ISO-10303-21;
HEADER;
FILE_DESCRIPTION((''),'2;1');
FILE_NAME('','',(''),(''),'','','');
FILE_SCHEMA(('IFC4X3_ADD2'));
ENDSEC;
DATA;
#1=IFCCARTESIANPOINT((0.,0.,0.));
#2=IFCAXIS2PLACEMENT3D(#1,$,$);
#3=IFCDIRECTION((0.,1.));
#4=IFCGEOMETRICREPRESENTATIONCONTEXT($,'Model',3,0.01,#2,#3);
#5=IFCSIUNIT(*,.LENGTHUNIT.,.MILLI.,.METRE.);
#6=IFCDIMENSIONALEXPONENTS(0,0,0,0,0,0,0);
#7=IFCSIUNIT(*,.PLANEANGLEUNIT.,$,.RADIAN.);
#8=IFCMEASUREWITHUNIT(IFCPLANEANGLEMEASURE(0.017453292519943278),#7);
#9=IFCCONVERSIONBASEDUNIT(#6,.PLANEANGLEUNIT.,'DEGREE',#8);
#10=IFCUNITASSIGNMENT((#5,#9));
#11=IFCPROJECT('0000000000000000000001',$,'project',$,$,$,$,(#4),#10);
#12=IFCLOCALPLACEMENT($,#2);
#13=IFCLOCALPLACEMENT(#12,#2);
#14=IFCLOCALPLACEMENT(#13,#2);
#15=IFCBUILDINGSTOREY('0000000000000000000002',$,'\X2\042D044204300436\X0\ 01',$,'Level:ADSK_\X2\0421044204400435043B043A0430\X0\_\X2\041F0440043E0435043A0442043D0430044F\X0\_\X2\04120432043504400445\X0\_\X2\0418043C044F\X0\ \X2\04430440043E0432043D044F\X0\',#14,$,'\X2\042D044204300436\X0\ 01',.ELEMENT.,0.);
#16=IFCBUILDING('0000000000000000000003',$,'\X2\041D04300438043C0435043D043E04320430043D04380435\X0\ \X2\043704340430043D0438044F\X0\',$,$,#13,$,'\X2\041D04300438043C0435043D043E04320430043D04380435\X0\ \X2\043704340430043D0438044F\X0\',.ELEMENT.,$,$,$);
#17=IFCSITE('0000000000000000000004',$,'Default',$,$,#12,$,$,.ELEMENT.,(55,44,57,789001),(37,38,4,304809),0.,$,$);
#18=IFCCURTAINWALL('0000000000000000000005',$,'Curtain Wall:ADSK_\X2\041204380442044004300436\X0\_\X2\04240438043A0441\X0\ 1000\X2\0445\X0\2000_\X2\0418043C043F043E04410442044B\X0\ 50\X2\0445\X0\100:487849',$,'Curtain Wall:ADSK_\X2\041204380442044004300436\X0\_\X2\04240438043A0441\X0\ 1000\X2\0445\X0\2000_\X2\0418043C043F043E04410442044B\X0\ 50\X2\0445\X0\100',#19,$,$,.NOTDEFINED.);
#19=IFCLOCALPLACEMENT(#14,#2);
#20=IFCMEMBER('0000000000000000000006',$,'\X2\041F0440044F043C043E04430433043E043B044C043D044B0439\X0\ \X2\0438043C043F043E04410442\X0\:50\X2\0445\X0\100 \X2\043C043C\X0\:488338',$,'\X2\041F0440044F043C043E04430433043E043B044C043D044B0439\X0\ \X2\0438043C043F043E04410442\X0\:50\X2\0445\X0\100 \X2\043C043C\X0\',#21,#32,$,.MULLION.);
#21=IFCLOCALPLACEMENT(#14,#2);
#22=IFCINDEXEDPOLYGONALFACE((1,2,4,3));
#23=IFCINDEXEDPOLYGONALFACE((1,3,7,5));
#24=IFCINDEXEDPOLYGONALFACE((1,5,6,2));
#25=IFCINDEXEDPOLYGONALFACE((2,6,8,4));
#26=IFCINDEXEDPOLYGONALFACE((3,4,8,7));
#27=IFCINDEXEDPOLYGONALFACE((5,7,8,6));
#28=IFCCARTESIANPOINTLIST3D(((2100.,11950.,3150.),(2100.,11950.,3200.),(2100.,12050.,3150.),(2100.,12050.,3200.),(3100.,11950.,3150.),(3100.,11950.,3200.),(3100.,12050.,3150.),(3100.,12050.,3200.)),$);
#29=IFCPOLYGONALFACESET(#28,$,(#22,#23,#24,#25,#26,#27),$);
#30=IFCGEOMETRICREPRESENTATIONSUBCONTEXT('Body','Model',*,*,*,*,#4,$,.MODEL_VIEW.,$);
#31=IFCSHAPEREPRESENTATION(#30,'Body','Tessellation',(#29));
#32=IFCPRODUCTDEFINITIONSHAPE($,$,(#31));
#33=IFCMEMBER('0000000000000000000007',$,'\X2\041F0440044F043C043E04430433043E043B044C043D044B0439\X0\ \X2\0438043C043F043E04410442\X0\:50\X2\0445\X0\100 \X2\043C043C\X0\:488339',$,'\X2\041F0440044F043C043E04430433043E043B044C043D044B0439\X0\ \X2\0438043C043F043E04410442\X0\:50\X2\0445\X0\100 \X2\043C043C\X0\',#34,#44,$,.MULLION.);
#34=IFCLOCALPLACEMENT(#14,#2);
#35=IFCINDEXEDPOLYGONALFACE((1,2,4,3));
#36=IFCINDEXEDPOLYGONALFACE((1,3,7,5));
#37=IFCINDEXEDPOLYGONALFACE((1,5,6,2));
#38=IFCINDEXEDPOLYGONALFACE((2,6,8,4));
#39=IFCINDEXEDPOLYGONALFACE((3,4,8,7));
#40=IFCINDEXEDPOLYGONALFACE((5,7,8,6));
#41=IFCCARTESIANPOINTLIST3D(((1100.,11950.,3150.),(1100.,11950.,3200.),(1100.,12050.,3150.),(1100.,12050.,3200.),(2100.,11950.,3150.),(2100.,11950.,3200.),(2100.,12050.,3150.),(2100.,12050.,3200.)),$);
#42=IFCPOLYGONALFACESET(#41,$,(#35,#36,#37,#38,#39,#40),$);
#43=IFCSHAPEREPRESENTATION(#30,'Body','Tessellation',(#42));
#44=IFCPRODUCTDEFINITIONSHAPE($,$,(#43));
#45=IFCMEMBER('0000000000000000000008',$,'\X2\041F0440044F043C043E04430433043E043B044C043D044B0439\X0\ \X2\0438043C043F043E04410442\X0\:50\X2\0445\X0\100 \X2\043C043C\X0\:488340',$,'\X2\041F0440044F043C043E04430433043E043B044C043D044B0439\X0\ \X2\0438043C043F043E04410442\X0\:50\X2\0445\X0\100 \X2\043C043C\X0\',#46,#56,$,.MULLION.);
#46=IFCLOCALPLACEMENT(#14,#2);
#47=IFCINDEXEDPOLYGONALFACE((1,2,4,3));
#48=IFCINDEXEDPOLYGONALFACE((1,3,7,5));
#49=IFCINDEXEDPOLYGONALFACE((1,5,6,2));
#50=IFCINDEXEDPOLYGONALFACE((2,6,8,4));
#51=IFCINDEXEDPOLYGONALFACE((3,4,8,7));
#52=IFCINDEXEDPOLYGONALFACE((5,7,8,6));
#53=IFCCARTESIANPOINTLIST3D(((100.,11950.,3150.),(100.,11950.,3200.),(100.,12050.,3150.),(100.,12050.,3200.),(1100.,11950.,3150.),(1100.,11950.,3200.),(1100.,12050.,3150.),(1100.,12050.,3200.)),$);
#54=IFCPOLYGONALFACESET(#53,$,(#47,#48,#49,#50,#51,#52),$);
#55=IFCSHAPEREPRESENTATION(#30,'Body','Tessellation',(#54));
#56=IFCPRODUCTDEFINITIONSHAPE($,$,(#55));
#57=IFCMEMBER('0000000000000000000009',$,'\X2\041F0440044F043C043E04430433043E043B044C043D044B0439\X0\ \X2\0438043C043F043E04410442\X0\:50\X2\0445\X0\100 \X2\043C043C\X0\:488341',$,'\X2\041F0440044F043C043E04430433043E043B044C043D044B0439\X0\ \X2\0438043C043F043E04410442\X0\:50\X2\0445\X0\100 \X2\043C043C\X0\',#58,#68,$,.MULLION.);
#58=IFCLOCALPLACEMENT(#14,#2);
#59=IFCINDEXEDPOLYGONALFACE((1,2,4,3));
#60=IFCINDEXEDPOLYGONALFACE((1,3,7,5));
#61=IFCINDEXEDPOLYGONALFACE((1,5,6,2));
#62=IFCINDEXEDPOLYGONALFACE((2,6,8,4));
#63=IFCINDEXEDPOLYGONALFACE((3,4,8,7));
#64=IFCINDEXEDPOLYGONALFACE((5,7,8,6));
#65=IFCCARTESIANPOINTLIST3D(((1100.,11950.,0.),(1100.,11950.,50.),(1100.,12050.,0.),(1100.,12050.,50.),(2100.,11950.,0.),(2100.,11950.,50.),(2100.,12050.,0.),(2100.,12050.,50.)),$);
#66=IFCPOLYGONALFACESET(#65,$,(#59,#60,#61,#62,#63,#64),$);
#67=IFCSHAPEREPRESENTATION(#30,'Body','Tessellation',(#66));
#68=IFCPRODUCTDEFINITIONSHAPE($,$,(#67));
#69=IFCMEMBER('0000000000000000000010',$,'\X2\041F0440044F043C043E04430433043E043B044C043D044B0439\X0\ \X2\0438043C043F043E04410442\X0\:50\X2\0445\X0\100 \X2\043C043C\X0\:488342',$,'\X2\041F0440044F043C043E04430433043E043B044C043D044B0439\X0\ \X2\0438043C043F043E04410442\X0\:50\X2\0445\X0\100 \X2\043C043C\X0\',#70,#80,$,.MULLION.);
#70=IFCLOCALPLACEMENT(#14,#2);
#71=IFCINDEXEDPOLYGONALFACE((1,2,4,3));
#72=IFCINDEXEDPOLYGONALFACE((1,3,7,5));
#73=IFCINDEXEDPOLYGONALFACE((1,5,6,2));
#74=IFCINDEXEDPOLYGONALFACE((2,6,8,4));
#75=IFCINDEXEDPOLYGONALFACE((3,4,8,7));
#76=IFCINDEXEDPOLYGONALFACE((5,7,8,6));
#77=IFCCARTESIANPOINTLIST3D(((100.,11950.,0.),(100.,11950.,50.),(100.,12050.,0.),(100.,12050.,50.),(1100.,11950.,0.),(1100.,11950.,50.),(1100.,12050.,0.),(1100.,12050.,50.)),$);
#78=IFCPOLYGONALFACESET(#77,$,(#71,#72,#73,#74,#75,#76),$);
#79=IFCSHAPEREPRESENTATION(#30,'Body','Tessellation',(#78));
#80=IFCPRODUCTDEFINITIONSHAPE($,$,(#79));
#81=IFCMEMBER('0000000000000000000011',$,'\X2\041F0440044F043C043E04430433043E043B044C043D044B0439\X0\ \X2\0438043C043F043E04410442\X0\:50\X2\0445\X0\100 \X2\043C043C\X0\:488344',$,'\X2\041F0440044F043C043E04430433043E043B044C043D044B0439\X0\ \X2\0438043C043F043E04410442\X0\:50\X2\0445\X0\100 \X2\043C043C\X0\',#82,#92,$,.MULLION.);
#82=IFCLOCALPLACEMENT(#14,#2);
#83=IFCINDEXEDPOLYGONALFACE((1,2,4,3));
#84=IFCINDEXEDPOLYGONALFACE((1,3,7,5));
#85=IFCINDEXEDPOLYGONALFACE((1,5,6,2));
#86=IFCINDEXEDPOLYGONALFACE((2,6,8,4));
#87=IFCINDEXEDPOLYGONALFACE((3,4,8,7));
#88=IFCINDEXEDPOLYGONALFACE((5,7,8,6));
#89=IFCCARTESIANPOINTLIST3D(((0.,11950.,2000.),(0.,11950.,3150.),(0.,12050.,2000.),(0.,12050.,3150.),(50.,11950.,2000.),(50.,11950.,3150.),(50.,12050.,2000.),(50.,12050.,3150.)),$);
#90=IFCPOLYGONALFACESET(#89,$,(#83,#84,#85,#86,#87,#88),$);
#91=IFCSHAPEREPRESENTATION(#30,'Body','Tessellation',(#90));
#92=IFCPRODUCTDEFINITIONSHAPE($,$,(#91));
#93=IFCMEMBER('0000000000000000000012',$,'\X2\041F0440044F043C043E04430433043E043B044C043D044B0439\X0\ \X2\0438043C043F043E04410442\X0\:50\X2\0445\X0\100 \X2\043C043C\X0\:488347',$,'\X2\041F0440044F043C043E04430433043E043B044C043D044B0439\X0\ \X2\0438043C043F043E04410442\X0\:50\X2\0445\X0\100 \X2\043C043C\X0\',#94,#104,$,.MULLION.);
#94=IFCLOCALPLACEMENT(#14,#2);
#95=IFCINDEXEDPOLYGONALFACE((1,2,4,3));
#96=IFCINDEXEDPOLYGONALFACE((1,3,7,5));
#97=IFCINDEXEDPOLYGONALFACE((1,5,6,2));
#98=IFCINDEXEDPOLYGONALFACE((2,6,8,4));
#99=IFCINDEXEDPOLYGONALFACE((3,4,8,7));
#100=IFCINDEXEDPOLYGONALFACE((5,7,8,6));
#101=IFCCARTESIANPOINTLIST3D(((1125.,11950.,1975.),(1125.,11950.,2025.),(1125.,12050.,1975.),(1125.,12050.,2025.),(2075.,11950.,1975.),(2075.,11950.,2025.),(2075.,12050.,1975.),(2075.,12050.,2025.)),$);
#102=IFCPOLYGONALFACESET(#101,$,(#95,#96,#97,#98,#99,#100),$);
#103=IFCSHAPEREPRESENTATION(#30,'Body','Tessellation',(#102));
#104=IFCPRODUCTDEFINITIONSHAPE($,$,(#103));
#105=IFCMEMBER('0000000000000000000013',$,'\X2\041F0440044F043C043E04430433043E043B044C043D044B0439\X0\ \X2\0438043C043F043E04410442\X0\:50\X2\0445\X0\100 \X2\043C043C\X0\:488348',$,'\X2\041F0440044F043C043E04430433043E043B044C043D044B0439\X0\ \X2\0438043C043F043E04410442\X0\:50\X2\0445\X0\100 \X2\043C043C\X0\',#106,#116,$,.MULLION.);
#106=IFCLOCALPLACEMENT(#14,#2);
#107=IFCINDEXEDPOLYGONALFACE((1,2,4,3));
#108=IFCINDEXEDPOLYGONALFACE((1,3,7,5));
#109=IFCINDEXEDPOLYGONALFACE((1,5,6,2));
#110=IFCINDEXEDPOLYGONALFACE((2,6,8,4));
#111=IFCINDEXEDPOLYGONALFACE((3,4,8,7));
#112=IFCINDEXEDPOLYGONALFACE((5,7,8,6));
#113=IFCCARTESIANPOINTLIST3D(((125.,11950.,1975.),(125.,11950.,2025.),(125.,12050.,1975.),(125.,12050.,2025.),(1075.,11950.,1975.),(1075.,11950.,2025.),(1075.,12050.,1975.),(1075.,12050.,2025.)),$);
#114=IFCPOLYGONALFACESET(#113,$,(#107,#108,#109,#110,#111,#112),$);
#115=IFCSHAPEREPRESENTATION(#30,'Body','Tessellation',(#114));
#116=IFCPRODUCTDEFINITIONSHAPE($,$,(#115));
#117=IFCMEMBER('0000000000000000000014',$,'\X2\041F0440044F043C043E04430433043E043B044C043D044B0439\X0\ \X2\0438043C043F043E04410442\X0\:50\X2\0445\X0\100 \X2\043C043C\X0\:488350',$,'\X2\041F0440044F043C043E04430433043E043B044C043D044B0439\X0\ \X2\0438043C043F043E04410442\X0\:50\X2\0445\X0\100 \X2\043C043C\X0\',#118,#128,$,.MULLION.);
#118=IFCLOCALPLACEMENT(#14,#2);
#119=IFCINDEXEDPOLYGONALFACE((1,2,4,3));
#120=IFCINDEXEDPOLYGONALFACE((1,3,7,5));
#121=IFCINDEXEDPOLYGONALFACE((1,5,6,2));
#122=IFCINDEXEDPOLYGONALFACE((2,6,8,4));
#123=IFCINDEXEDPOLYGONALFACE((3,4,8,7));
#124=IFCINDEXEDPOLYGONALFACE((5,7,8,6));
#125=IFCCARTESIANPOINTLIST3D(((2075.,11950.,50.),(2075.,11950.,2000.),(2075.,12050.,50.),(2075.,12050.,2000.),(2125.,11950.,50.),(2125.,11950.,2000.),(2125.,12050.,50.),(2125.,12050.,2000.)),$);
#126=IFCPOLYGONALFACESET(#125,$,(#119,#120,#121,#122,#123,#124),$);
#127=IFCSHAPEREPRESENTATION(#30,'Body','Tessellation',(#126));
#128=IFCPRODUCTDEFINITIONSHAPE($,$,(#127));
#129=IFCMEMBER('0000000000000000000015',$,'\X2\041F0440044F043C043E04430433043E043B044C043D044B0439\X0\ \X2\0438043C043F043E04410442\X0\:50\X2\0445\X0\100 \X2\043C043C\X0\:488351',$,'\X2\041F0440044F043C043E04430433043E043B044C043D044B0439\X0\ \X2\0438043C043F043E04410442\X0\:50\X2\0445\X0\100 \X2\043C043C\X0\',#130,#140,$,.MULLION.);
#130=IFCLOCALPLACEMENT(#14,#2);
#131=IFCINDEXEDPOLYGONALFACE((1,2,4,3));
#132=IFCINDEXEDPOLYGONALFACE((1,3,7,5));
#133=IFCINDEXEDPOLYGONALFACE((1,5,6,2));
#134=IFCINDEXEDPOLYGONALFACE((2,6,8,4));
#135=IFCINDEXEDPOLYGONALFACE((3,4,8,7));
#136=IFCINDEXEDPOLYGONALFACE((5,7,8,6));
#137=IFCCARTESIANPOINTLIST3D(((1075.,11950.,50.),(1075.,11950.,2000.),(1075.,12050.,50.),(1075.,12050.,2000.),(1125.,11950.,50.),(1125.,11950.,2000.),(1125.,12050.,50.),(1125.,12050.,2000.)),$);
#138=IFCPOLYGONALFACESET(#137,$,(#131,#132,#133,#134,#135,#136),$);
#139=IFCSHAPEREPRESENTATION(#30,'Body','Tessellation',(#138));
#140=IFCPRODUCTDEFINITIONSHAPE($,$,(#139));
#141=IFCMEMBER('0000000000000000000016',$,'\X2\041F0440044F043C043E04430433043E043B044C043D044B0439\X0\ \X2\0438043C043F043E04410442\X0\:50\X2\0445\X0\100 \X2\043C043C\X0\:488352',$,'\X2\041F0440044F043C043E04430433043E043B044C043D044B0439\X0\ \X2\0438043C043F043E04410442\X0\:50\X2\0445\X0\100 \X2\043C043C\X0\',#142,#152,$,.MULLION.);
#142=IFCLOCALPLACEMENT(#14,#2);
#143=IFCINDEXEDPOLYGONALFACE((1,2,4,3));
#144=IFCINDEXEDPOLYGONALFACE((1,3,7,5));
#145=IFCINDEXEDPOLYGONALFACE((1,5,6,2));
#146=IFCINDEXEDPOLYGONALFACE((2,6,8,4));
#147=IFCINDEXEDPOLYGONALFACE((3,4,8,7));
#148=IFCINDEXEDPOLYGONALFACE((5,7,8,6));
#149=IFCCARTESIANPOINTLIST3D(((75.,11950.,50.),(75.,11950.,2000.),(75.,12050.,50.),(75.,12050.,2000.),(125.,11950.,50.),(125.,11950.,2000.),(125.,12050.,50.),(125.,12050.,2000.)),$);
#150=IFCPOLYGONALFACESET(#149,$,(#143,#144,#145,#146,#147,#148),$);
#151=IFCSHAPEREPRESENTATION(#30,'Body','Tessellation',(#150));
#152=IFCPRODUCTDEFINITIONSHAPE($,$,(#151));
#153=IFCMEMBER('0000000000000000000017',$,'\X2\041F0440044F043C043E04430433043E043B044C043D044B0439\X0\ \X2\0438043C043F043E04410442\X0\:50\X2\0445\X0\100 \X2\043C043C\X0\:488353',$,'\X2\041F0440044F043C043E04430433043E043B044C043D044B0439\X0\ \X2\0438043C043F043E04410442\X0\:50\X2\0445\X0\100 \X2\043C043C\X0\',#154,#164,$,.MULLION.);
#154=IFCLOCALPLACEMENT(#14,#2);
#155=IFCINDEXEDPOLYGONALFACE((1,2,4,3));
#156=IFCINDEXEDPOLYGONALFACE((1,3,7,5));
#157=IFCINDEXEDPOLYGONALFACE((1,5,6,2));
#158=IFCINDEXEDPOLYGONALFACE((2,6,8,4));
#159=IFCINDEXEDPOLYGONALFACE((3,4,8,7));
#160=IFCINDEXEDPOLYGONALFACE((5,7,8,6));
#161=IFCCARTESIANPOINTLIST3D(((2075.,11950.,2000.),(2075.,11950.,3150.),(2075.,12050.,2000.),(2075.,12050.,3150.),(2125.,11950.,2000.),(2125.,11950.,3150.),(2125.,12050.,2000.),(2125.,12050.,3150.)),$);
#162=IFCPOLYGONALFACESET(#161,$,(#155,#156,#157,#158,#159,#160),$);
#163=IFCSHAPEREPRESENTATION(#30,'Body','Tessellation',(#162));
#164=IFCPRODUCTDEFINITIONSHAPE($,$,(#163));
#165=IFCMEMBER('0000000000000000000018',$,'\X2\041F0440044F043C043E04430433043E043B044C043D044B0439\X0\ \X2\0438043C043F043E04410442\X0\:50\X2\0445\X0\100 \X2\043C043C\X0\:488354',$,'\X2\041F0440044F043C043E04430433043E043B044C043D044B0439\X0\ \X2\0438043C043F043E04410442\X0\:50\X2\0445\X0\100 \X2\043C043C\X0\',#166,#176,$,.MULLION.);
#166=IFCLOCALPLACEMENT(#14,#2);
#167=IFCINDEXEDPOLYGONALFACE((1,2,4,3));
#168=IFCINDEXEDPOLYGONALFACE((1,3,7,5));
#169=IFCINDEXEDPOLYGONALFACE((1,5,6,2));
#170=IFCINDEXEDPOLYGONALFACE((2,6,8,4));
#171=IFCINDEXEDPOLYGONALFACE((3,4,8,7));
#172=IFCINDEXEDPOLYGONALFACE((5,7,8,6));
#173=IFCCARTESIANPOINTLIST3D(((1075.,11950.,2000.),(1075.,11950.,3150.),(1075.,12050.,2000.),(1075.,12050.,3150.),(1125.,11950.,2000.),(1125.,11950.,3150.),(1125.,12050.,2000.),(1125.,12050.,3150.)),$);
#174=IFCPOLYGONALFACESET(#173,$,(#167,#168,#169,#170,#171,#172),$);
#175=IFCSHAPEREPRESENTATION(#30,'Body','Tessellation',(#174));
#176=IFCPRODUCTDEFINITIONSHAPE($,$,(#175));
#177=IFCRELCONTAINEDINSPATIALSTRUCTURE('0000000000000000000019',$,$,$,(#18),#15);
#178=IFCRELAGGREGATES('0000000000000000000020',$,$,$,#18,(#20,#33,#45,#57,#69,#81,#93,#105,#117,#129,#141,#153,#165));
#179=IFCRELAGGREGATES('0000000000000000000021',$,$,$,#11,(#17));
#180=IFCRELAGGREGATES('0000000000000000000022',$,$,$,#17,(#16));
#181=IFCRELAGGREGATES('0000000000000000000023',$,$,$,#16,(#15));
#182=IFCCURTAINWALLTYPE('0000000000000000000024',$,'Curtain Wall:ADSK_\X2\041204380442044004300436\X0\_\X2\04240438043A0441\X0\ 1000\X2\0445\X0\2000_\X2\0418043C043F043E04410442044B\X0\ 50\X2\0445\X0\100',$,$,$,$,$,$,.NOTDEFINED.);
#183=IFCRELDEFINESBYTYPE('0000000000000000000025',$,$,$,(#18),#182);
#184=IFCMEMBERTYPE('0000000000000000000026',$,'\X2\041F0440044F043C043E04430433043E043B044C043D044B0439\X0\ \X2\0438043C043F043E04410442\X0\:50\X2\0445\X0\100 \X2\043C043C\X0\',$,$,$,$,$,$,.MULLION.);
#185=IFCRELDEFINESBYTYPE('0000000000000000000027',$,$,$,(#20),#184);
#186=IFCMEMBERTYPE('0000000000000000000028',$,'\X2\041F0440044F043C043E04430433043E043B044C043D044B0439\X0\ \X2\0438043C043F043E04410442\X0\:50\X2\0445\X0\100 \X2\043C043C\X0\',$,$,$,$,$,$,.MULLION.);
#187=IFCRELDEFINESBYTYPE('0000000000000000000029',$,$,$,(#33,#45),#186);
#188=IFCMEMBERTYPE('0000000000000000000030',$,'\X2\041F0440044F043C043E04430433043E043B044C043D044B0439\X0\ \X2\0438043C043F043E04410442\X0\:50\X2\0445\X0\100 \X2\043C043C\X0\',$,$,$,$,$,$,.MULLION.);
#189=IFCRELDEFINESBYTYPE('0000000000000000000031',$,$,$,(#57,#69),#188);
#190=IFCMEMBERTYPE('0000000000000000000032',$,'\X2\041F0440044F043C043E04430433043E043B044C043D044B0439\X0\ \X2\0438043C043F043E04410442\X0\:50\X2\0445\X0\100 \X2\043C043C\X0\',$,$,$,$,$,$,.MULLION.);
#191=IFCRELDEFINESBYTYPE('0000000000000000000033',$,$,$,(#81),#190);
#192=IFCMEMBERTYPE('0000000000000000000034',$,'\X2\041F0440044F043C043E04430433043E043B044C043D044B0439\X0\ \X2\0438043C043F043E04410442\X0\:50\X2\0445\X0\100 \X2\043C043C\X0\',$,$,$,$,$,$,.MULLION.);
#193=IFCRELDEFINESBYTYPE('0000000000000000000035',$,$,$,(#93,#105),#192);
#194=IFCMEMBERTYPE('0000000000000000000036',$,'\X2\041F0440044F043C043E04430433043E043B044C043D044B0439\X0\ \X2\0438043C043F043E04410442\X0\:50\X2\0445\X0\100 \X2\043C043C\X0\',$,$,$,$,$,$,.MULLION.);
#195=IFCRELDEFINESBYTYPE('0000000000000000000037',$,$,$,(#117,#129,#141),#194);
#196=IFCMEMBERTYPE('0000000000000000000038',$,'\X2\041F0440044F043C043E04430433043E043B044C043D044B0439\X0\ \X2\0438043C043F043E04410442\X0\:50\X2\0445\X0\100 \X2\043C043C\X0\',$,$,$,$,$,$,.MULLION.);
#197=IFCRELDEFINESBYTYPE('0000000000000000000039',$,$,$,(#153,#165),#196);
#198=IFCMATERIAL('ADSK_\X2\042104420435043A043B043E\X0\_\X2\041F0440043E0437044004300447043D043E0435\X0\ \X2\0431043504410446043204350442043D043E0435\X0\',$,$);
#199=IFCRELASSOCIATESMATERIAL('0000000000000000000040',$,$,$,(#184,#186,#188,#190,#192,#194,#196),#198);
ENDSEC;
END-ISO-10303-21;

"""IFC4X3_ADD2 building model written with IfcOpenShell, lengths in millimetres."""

from ifc_helpers import new_model, entity, si_unit, converted_unit, direction, frame, frame_2d, origin, place, context, subcontext, project, spatial, rectangle, extrude, source, transform, mapped, material, material_profile, profile_set, type_object, type_shapes, element, aggregate, save


model = new_model("IFC4X3_ADD2")

# Units and contexts
model_context = context("Model", 3, precision=0.01, world=origin(), true_north=direction((0.0, 1.0)))
body_context = subcontext(model_context, "Body", "Model", "MODEL_VIEW")
ifc_project = project(units=[si_unit("LENGTHUNIT", "METRE", prefix="MILLI"), converted_unit("PLANEANGLEUNIT", "DEGREE", entity("IfcPlaneAngleMeasure", 0.017453292519943278), si_unit("PLANEANGLEUNIT", "RADIAN"), dimensions=[0, 0, 0, 0, 0, 0, 0])], contexts=[model_context])

# Site, building, storey
site_placement = place(None, origin())
site = spatial("IfcSite", under=ifc_project, at=site_placement, Name="Default", CompositionType="ELEMENT", RefLatitude=(55, 44, 57, 789001), RefLongitude=(37, 38, 4, 304809), RefElevation=0.0)
building_placement = place(site_placement, origin())
building = spatial("IfcBuilding", under=site, at=building_placement, Name="Наименование здания", LongName="Наименование здания", CompositionType="ELEMENT")
storey_placement = place(building_placement, origin())
storey = spatial("IfcBuildingStorey", under=building, at=storey_placement, Name="Этаж 01", ObjectType="Level:ADSK_Стрелка_Проектная_Вверх_Имя уровня", LongName="Этаж 01", CompositionType="ELEMENT", Elevation=0.0)

# Curtain wall, members
curtain_wall_type = type_object("IfcCurtainWallType", Name="Curtain Wall:ADSK_Витраж_Фикс 1000х2000_Импосты 50х100", PredefinedType="NOTDEFINED")
curtain_wall_1_placement = place(storey_placement, origin())
curtain_wall_1 = element("IfcCurtainWall", 1, at=curtain_wall_1_placement, inside=storey, type_object=curtain_wall_type, Name="Curtain Wall:ADSK_Витраж_Фикс 1000х2000_Импосты 50х100:487849", ObjectType="Curtain Wall:ADSK_Витраж_Фикс 1000х2000_Импосты 50х100", PredefinedType="NOTDEFINED")
ifc_material = material(Name="ADSK_Стекло_Прозрачное бесцветное")
ifc_material_profile = material_profile(ifc_material, rectangle(XDim=50.0, YDim=100.0, at=frame_2d((0.0, 0.0), x_axis=(1.0, 0.0))), Name="50х100 мм")
ifc_profile_set = profile_set([ifc_material_profile], Name="50х100 мм")
member_type_1 = type_object("IfcMemberType", Name="Прямоугольный импост:50х100 мм", PredefinedType="MULLION", material=ifc_profile_set)
shared_shape_1 = source(origin(), body_context, "Body", "SweptSolid", [
    extrude(rectangle(XDim=50.0, YDim=100.0, at=frame_2d((0.0, 0.0), x_axis=(1.0, 0.0))), frame((-25.0, 0.0, -1000.0), z_axis=(0.0, 0.0, 1.0), x_axis=(-1.0, 0.0, 0.0)), (0.0, 0.0, 1.0), 1000.0),
])
type_shapes(member_type_1, [shared_shape_1])
member_1_placement = place(curtain_wall_1_placement, frame((2100.0, 12000.0, 3200.0), z_axis=(-1.0, 0.0, 0.0), x_axis=(0.0, 0.0, 1.0)))
member_1 = element("IfcMember", 2, at=member_1_placement, type_object=member_type_1, Name="Прямоугольный импост:50х100 мм:488338", ObjectType="Прямоугольный импост:50х100 мм", PredefinedType="MULLION", context=body_context, shape_type="MappedRepresentation", body=[
    mapped(shared_shape_1, transform((0.0, 0.0, 0.0), scale=1.0)),
])
member_type_2 = type_object("IfcMemberType", Name="Прямоугольный импост:50х100 мм", PredefinedType="MULLION", material=ifc_profile_set)
shared_shape_2 = source(origin(), body_context, "Body", "SweptSolid", [
    extrude(rectangle(XDim=50.0, YDim=100.0, at=frame_2d((0.0, 0.0), x_axis=(1.0, 0.0))), frame((-25.0, 0.0, -1000.0), z_axis=(0.0, 0.0, 1.0), x_axis=(-1.0, 0.0, 0.0)), (0.0, 0.0, 1.0), 1000.0),
])
type_shapes(member_type_2, [shared_shape_2])
member_2_placement = place(curtain_wall_1_placement, frame((1100.0, 12000.0, 3200.0), z_axis=(-1.0, 0.0, 0.0), x_axis=(0.0, 0.0, 1.0)))
member_2 = element("IfcMember", 3, at=member_2_placement, type_object=member_type_2, Name="Прямоугольный импост:50х100 мм:488339", ObjectType="Прямоугольный импост:50х100 мм", PredefinedType="MULLION", context=body_context, shape_type="MappedRepresentation", body=[
    mapped(shared_shape_2, transform((0.0, 0.0, 0.0), scale=1.0)),
])
member_3_placement = place(curtain_wall_1_placement, frame((100.0, 12000.0, 3200.0), z_axis=(-1.0, 0.0, 0.0), x_axis=(0.0, 0.0, 1.0)))
member_3 = element("IfcMember", 4, at=member_3_placement, type_object=member_type_2, Name="Прямоугольный импост:50х100 мм:488340", ObjectType="Прямоугольный импост:50х100 мм", PredefinedType="MULLION", context=body_context, shape_type="MappedRepresentation", body=[
    mapped(shared_shape_2, transform((0.0, 0.0, 0.0), scale=1.0)),
])
member_type_3 = type_object("IfcMemberType", Name="Прямоугольный импост:50х100 мм", PredefinedType="MULLION", material=ifc_profile_set)
shared_shape_3 = source(origin(), body_context, "Body", "SweptSolid", [
    extrude(rectangle(XDim=50.0, YDim=100.0, at=frame_2d((0.0, 0.0), x_axis=(1.0, 0.0))), frame((-25.0, 0.0, -1000.0), z_axis=(0.0, 0.0, 1.0), x_axis=(-1.0, 0.0, 0.0)), (0.0, 0.0, 1.0), 1000.0),
])
type_shapes(member_type_3, [shared_shape_3])
member_4_placement = place(curtain_wall_1_placement, frame((2100.0, 12000.0, 0.0), z_axis=(1.0, 0.0, 0.0), x_axis=(0.0, 0.0, -1.0)))
member_4 = element("IfcMember", 5, at=member_4_placement, type_object=member_type_3, Name="Прямоугольный импост:50х100 мм:488341", ObjectType="Прямоугольный импост:50х100 мм", PredefinedType="MULLION", context=body_context, shape_type="MappedRepresentation", body=[
    mapped(shared_shape_3, transform((0.0, 0.0, 0.0), scale=1.0)),
])
member_5_placement = place(curtain_wall_1_placement, frame((1100.0, 12000.0, 0.0), z_axis=(1.0, 0.0, 0.0), x_axis=(0.0, 0.0, -1.0)))
member_5 = element("IfcMember", 6, at=member_5_placement, type_object=member_type_3, Name="Прямоугольный импост:50х100 мм:488342", ObjectType="Прямоугольный импост:50х100 мм", PredefinedType="MULLION", context=body_context, shape_type="MappedRepresentation", body=[
    mapped(shared_shape_3, transform((0.0, 0.0, 0.0), scale=1.0)),
])
member_type_4 = type_object("IfcMemberType", Name="Прямоугольный импост:50х100 мм", PredefinedType="MULLION", material=ifc_profile_set)
shared_shape_4 = source(origin(), body_context, "Body", "SweptSolid", [
    extrude(rectangle(XDim=50.0, YDim=100.0, at=frame_2d((0.0, 0.0), x_axis=(1.0, 0.0))), frame((-25.0, 0.0, -1150.0), z_axis=(0.0, 0.0, 1.0), x_axis=(-1.0, 0.0, 0.0)), (0.0, 0.0, 1.0), 1150.0),
])
type_shapes(member_type_4, [shared_shape_4])
member_6_placement = place(curtain_wall_1_placement, frame((0.0, 12000.0, 2000.0), z_axis=(0.0, 0.0, -1.0), x_axis=(-1.0, 0.0, 0.0)))
member_6 = element("IfcMember", 7, at=member_6_placement, type_object=member_type_4, Name="Прямоугольный импост:50х100 мм:488344", ObjectType="Прямоугольный импост:50х100 мм", PredefinedType="MULLION", context=body_context, shape_type="MappedRepresentation", body=[
    mapped(shared_shape_4, transform((0.0, 0.0, 0.0), scale=1.0)),
])
member_type_5 = type_object("IfcMemberType", Name="Прямоугольный импост:50х100 мм", PredefinedType="MULLION", material=ifc_profile_set)
shared_shape_5 = source(origin(), body_context, "Body", "SweptSolid", [
    extrude(rectangle(XDim=50.0, YDim=100.0, at=frame_2d((0.0, 0.0), x_axis=(1.0, 0.0))), frame((0.0, 0.0, -950.0), z_axis=(0.0, 0.0, 1.0), x_axis=(-1.0, 0.0, 0.0)), (0.0, 0.0, 1.0), 950.0),
])
type_shapes(member_type_5, [shared_shape_5])
member_7_placement = place(curtain_wall_1_placement, frame((1125.0, 12000.0, 2000.0), z_axis=(-1.0, 0.0, 0.0), x_axis=(0.0, 0.0, 1.0)))
member_7 = element("IfcMember", 8, at=member_7_placement, type_object=member_type_5, Name="Прямоугольный импост:50х100 мм:488347", ObjectType="Прямоугольный импост:50х100 мм", PredefinedType="MULLION", context=body_context, shape_type="MappedRepresentation", body=[
    mapped(shared_shape_5, transform((0.0, 0.0, 0.0), scale=1.0)),
])
member_8_placement = place(curtain_wall_1_placement, frame((125.0, 12000.0, 2000.0), z_axis=(-1.0, 0.0, 0.0), x_axis=(0.0, 0.0, 1.0)))
member_8 = element("IfcMember", 9, at=member_8_placement, type_object=member_type_5, Name="Прямоугольный импост:50х100 мм:488348", ObjectType="Прямоугольный импост:50х100 мм", PredefinedType="MULLION", context=body_context, shape_type="MappedRepresentation", body=[
    mapped(shared_shape_5, transform((0.0, 0.0, 0.0), scale=1.0)),
])
member_type_6 = type_object("IfcMemberType", Name="Прямоугольный импост:50х100 мм", PredefinedType="MULLION", material=ifc_profile_set)
shared_shape_6 = source(origin(), body_context, "Body", "SweptSolid", [
    extrude(rectangle(XDim=50.0, YDim=100.0, at=frame_2d((0.0, 0.0), x_axis=(1.0, 0.0))), frame((0.0, 0.0, -1950.0), z_axis=(0.0, 0.0, 1.0), x_axis=(-1.0, 0.0, 0.0)), (0.0, 0.0, 1.0), 1950.0),
])
type_shapes(member_type_6, [shared_shape_6])
member_9_placement = place(curtain_wall_1_placement, frame((2100.0, 12000.0, 50.0), z_axis=(0.0, 0.0, -1.0), x_axis=(-1.0, 0.0, 0.0)))
member_9 = element("IfcMember", 10, at=member_9_placement, type_object=member_type_6, Name="Прямоугольный импост:50х100 мм:488350", ObjectType="Прямоугольный импост:50х100 мм", PredefinedType="MULLION", context=body_context, shape_type="MappedRepresentation", body=[
    mapped(shared_shape_6, transform((0.0, 0.0, 0.0), scale=1.0)),
])
member_10_placement = place(curtain_wall_1_placement, frame((1100.0, 12000.0, 50.0), z_axis=(0.0, 0.0, -1.0), x_axis=(-1.0, 0.0, 0.0)))
member_10 = element("IfcMember", 11, at=member_10_placement, type_object=member_type_6, Name="Прямоугольный импост:50х100 мм:488351", ObjectType="Прямоугольный импост:50х100 мм", PredefinedType="MULLION", context=body_context, shape_type="MappedRepresentation", body=[
    mapped(shared_shape_6, transform((0.0, 0.0, 0.0), scale=1.0)),
])
member_11_placement = place(curtain_wall_1_placement, frame((100.0, 12000.0, 50.0), z_axis=(0.0, 0.0, -1.0), x_axis=(-1.0, 0.0, 0.0)))
member_11 = element("IfcMember", 12, at=member_11_placement, type_object=member_type_6, Name="Прямоугольный импост:50х100 мм:488352", ObjectType="Прямоугольный импост:50х100 мм", PredefinedType="MULLION", context=body_context, shape_type="MappedRepresentation", body=[
    mapped(shared_shape_6, transform((0.0, 0.0, 0.0), scale=1.0)),
])
member_type_7 = type_object("IfcMemberType", Name="Прямоугольный импост:50х100 мм", PredefinedType="MULLION", material=ifc_profile_set)
shared_shape_7 = source(origin(), body_context, "Body", "SweptSolid", [
    extrude(rectangle(XDim=50.0, YDim=100.0, at=frame_2d((0.0, 0.0), x_axis=(1.0, 0.0))), frame((0.0, 0.0, -1150.0), z_axis=(0.0, 0.0, 1.0), x_axis=(-1.0, 0.0, 0.0)), (0.0, 0.0, 1.0), 1150.0),
])
type_shapes(member_type_7, [shared_shape_7])
member_12_placement = place(curtain_wall_1_placement, frame((2100.0, 12000.0, 2000.0), z_axis=(0.0, 0.0, -1.0), x_axis=(-1.0, 0.0, 0.0)))
member_12 = element("IfcMember", 13, at=member_12_placement, type_object=member_type_7, Name="Прямоугольный импост:50х100 мм:488353", ObjectType="Прямоугольный импост:50х100 мм", PredefinedType="MULLION", context=body_context, shape_type="MappedRepresentation", body=[
    mapped(shared_shape_7, transform((0.0, 0.0, 0.0), scale=1.0)),
])
member_13_placement = place(curtain_wall_1_placement, frame((1100.0, 12000.0, 2000.0), z_axis=(0.0, 0.0, -1.0), x_axis=(-1.0, 0.0, 0.0)))
member_13 = element("IfcMember", 14, at=member_13_placement, type_object=member_type_7, Name="Прямоугольный импост:50х100 мм:488354", ObjectType="Прямоугольный импост:50х100 мм", PredefinedType="MULLION", context=body_context, shape_type="MappedRepresentation", body=[
    mapped(shared_shape_7, transform((0.0, 0.0, 0.0), scale=1.0)),
])

aggregate(curtain_wall_1, [member_1, member_2, member_3, member_4, member_5, member_6, member_7, member_8, member_9, member_10, member_11, member_12, member_13])

save(model, "model.ifc")
